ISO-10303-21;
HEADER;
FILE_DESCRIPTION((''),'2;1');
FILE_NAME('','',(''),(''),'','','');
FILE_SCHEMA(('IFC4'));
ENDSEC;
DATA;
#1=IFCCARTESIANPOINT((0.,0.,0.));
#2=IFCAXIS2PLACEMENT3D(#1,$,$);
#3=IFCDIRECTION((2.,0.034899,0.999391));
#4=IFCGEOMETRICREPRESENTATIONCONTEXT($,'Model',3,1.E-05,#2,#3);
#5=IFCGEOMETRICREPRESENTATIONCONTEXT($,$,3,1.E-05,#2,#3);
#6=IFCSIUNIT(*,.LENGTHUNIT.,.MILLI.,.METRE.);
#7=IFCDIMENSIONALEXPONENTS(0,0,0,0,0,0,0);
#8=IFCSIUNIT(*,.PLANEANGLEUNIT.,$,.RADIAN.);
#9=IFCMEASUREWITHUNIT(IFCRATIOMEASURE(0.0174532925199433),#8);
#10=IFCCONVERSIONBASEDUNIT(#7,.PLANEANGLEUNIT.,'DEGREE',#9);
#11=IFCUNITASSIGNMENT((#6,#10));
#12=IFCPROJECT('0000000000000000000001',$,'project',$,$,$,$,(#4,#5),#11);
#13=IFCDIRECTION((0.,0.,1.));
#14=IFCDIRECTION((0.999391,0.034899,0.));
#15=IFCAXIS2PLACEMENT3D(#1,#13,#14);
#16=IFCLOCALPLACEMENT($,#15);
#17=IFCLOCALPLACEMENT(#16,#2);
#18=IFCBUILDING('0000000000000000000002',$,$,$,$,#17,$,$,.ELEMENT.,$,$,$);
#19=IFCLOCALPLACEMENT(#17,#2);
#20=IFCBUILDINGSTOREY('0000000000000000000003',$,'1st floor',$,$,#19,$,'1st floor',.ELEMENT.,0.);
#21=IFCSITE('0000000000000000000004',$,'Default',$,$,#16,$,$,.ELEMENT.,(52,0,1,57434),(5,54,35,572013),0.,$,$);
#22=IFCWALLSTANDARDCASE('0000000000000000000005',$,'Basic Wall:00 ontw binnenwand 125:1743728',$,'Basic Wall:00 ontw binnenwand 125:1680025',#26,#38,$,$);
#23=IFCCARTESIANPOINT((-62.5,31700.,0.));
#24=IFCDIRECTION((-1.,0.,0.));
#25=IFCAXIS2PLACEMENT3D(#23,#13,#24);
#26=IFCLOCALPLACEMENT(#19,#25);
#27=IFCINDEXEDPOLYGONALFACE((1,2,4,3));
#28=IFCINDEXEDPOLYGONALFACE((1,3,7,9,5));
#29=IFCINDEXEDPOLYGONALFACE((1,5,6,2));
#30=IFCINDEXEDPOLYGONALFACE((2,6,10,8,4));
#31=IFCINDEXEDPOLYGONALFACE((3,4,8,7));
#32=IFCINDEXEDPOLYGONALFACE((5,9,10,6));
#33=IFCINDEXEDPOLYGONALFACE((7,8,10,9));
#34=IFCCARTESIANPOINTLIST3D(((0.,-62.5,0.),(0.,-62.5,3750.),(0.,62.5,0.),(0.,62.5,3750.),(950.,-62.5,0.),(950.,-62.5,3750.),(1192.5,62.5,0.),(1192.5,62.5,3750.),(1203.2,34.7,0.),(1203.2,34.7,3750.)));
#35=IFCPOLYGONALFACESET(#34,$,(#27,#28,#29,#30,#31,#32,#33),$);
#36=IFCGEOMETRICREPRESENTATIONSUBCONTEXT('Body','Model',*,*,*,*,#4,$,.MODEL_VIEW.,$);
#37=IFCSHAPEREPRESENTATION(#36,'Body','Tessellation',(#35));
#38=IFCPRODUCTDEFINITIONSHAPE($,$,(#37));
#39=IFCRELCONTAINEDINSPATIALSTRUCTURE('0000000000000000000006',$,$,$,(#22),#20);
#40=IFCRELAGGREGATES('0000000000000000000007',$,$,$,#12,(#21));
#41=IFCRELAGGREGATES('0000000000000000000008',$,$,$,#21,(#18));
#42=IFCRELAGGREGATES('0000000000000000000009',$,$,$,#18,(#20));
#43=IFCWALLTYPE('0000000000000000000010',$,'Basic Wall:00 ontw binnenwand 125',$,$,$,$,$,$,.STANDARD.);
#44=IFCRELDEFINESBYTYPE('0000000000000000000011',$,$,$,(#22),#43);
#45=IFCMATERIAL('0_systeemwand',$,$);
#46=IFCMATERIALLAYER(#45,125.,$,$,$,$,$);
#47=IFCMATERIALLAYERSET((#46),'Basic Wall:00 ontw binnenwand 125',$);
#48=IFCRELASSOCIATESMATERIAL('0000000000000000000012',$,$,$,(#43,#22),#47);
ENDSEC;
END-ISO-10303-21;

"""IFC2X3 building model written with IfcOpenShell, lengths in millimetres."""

from ifc_helpers import new_model, entity, si_unit, converted_unit, direction, frame, origin, origin_2d_with_axis, place, context, subcontext, project, spatial, polyline, rectangle, outline, extrude, material, layer, layer_set, layer_usage, type_object, element, save


model = new_model("IFC2X3")

# Units and contexts
model_context = context("Model", 3, precision=1e-05, world=origin(), true_north=direction((2.0, 0.034899, 0.999391)))
context_of_model = context(None, 3, precision=1e-05, world=origin(), true_north=direction((2.0, 0.034899, 0.999391)))
body_context = subcontext(model_context, "Body", "Model", "MODEL_VIEW")
ifc_project = project(units=[si_unit("LENGTHUNIT", "METRE", prefix="MILLI"), converted_unit("PLANEANGLEUNIT", "DEGREE", entity("IfcRatioMeasure", 0.0174532925199433), si_unit("PLANEANGLEUNIT", "RADIAN"), dimensions=[0, 0, 0, 0, 0, 0, 0])], contexts=[model_context, context_of_model])

# Site, building, storey
site_placement = place(None, frame((0.0, 0.0, 0.0), z_axis=(0.0, 0.0, 1.0), x_axis=(0.999391, 0.034899, 0.0)))
site = spatial("IfcSite", under=ifc_project, at=site_placement, Name="Default", CompositionType="ELEMENT", RefLatitude=(52, 0, 1, 57434), RefLongitude=(5, 54, 35, 572013), RefElevation=0.0)
building_placement = place(site_placement, origin())
building = spatial("IfcBuilding", under=site, at=building_placement, CompositionType="ELEMENT")
storey_placement = place(building_placement, origin())
storey = spatial("IfcBuildingStorey", under=building, at=storey_placement, Name="1st floor", LongName="1st floor", CompositionType="ELEMENT", Elevation=0.0)

# Shared definitions
ifc_material_1 = material(Name="0_systeemwand")
ifc_layer_1 = layer(ifc_material_1, 125.0)
ifc_layer_set_1 = layer_set([ifc_layer_1], Name="Basic Wall:00 ontw binnenwand 125")
wall_type_1 = type_object("IfcWallType", Name="Basic Wall:00 ontw binnenwand 125", PredefinedType="STANDARD", material=ifc_layer_set_1)

# Wall, opening
ifc_layer_usage_1 = layer_usage(ifc_layer_set_1, "AXIS2", "POSITIVE", -62.5)
wall_1_placement = place(storey_placement, frame((-62.5, 31700.0, 0.0), z_axis=(0.0, 0.0, 1.0), x_axis=(-1.0, 0.0, 0.0)))
wall_1 = element("IfcWallStandardCase", 1, at=wall_1_placement, inside=storey, type_object=wall_type_1, material=ifc_layer_usage_1, Name="Basic Wall:00 ontw binnenwand 125:1743728", ObjectType="Basic Wall:00 ontw binnenwand 125:1680025", context=body_context, shape_type="SweptSolid", body=[
    extrude(outline(polyline([(950.0, -62.5), (1203.2, 34.7), (1192.5, 62.5), (926.8, 62.5), (0.0, 62.5), (0.0, -62.5), (950.0, -62.5)])), origin(), (0.0, 0.0, 1.0), 3750.0),
])
opening_1_placement = place(wall_1_placement, origin())
element("IfcOpeningElement", 2, at=opening_1_placement, cuts=wall_1, ObjectType="Recess", context=body_context, shape_type="SweptSolid", body=[
    extrude(rectangle(XDim=125.0, YDim=1090.0, at=origin_2d_with_axis()), frame((1689.6, 288.3, 0.0), z_axis=(0.0, 0.0, 1.0), x_axis=(-0.358368, 0.93358, 0.0)), (0.0, 0.0, 1.0), 2365.0),
])

save(model, "model.ifc")
